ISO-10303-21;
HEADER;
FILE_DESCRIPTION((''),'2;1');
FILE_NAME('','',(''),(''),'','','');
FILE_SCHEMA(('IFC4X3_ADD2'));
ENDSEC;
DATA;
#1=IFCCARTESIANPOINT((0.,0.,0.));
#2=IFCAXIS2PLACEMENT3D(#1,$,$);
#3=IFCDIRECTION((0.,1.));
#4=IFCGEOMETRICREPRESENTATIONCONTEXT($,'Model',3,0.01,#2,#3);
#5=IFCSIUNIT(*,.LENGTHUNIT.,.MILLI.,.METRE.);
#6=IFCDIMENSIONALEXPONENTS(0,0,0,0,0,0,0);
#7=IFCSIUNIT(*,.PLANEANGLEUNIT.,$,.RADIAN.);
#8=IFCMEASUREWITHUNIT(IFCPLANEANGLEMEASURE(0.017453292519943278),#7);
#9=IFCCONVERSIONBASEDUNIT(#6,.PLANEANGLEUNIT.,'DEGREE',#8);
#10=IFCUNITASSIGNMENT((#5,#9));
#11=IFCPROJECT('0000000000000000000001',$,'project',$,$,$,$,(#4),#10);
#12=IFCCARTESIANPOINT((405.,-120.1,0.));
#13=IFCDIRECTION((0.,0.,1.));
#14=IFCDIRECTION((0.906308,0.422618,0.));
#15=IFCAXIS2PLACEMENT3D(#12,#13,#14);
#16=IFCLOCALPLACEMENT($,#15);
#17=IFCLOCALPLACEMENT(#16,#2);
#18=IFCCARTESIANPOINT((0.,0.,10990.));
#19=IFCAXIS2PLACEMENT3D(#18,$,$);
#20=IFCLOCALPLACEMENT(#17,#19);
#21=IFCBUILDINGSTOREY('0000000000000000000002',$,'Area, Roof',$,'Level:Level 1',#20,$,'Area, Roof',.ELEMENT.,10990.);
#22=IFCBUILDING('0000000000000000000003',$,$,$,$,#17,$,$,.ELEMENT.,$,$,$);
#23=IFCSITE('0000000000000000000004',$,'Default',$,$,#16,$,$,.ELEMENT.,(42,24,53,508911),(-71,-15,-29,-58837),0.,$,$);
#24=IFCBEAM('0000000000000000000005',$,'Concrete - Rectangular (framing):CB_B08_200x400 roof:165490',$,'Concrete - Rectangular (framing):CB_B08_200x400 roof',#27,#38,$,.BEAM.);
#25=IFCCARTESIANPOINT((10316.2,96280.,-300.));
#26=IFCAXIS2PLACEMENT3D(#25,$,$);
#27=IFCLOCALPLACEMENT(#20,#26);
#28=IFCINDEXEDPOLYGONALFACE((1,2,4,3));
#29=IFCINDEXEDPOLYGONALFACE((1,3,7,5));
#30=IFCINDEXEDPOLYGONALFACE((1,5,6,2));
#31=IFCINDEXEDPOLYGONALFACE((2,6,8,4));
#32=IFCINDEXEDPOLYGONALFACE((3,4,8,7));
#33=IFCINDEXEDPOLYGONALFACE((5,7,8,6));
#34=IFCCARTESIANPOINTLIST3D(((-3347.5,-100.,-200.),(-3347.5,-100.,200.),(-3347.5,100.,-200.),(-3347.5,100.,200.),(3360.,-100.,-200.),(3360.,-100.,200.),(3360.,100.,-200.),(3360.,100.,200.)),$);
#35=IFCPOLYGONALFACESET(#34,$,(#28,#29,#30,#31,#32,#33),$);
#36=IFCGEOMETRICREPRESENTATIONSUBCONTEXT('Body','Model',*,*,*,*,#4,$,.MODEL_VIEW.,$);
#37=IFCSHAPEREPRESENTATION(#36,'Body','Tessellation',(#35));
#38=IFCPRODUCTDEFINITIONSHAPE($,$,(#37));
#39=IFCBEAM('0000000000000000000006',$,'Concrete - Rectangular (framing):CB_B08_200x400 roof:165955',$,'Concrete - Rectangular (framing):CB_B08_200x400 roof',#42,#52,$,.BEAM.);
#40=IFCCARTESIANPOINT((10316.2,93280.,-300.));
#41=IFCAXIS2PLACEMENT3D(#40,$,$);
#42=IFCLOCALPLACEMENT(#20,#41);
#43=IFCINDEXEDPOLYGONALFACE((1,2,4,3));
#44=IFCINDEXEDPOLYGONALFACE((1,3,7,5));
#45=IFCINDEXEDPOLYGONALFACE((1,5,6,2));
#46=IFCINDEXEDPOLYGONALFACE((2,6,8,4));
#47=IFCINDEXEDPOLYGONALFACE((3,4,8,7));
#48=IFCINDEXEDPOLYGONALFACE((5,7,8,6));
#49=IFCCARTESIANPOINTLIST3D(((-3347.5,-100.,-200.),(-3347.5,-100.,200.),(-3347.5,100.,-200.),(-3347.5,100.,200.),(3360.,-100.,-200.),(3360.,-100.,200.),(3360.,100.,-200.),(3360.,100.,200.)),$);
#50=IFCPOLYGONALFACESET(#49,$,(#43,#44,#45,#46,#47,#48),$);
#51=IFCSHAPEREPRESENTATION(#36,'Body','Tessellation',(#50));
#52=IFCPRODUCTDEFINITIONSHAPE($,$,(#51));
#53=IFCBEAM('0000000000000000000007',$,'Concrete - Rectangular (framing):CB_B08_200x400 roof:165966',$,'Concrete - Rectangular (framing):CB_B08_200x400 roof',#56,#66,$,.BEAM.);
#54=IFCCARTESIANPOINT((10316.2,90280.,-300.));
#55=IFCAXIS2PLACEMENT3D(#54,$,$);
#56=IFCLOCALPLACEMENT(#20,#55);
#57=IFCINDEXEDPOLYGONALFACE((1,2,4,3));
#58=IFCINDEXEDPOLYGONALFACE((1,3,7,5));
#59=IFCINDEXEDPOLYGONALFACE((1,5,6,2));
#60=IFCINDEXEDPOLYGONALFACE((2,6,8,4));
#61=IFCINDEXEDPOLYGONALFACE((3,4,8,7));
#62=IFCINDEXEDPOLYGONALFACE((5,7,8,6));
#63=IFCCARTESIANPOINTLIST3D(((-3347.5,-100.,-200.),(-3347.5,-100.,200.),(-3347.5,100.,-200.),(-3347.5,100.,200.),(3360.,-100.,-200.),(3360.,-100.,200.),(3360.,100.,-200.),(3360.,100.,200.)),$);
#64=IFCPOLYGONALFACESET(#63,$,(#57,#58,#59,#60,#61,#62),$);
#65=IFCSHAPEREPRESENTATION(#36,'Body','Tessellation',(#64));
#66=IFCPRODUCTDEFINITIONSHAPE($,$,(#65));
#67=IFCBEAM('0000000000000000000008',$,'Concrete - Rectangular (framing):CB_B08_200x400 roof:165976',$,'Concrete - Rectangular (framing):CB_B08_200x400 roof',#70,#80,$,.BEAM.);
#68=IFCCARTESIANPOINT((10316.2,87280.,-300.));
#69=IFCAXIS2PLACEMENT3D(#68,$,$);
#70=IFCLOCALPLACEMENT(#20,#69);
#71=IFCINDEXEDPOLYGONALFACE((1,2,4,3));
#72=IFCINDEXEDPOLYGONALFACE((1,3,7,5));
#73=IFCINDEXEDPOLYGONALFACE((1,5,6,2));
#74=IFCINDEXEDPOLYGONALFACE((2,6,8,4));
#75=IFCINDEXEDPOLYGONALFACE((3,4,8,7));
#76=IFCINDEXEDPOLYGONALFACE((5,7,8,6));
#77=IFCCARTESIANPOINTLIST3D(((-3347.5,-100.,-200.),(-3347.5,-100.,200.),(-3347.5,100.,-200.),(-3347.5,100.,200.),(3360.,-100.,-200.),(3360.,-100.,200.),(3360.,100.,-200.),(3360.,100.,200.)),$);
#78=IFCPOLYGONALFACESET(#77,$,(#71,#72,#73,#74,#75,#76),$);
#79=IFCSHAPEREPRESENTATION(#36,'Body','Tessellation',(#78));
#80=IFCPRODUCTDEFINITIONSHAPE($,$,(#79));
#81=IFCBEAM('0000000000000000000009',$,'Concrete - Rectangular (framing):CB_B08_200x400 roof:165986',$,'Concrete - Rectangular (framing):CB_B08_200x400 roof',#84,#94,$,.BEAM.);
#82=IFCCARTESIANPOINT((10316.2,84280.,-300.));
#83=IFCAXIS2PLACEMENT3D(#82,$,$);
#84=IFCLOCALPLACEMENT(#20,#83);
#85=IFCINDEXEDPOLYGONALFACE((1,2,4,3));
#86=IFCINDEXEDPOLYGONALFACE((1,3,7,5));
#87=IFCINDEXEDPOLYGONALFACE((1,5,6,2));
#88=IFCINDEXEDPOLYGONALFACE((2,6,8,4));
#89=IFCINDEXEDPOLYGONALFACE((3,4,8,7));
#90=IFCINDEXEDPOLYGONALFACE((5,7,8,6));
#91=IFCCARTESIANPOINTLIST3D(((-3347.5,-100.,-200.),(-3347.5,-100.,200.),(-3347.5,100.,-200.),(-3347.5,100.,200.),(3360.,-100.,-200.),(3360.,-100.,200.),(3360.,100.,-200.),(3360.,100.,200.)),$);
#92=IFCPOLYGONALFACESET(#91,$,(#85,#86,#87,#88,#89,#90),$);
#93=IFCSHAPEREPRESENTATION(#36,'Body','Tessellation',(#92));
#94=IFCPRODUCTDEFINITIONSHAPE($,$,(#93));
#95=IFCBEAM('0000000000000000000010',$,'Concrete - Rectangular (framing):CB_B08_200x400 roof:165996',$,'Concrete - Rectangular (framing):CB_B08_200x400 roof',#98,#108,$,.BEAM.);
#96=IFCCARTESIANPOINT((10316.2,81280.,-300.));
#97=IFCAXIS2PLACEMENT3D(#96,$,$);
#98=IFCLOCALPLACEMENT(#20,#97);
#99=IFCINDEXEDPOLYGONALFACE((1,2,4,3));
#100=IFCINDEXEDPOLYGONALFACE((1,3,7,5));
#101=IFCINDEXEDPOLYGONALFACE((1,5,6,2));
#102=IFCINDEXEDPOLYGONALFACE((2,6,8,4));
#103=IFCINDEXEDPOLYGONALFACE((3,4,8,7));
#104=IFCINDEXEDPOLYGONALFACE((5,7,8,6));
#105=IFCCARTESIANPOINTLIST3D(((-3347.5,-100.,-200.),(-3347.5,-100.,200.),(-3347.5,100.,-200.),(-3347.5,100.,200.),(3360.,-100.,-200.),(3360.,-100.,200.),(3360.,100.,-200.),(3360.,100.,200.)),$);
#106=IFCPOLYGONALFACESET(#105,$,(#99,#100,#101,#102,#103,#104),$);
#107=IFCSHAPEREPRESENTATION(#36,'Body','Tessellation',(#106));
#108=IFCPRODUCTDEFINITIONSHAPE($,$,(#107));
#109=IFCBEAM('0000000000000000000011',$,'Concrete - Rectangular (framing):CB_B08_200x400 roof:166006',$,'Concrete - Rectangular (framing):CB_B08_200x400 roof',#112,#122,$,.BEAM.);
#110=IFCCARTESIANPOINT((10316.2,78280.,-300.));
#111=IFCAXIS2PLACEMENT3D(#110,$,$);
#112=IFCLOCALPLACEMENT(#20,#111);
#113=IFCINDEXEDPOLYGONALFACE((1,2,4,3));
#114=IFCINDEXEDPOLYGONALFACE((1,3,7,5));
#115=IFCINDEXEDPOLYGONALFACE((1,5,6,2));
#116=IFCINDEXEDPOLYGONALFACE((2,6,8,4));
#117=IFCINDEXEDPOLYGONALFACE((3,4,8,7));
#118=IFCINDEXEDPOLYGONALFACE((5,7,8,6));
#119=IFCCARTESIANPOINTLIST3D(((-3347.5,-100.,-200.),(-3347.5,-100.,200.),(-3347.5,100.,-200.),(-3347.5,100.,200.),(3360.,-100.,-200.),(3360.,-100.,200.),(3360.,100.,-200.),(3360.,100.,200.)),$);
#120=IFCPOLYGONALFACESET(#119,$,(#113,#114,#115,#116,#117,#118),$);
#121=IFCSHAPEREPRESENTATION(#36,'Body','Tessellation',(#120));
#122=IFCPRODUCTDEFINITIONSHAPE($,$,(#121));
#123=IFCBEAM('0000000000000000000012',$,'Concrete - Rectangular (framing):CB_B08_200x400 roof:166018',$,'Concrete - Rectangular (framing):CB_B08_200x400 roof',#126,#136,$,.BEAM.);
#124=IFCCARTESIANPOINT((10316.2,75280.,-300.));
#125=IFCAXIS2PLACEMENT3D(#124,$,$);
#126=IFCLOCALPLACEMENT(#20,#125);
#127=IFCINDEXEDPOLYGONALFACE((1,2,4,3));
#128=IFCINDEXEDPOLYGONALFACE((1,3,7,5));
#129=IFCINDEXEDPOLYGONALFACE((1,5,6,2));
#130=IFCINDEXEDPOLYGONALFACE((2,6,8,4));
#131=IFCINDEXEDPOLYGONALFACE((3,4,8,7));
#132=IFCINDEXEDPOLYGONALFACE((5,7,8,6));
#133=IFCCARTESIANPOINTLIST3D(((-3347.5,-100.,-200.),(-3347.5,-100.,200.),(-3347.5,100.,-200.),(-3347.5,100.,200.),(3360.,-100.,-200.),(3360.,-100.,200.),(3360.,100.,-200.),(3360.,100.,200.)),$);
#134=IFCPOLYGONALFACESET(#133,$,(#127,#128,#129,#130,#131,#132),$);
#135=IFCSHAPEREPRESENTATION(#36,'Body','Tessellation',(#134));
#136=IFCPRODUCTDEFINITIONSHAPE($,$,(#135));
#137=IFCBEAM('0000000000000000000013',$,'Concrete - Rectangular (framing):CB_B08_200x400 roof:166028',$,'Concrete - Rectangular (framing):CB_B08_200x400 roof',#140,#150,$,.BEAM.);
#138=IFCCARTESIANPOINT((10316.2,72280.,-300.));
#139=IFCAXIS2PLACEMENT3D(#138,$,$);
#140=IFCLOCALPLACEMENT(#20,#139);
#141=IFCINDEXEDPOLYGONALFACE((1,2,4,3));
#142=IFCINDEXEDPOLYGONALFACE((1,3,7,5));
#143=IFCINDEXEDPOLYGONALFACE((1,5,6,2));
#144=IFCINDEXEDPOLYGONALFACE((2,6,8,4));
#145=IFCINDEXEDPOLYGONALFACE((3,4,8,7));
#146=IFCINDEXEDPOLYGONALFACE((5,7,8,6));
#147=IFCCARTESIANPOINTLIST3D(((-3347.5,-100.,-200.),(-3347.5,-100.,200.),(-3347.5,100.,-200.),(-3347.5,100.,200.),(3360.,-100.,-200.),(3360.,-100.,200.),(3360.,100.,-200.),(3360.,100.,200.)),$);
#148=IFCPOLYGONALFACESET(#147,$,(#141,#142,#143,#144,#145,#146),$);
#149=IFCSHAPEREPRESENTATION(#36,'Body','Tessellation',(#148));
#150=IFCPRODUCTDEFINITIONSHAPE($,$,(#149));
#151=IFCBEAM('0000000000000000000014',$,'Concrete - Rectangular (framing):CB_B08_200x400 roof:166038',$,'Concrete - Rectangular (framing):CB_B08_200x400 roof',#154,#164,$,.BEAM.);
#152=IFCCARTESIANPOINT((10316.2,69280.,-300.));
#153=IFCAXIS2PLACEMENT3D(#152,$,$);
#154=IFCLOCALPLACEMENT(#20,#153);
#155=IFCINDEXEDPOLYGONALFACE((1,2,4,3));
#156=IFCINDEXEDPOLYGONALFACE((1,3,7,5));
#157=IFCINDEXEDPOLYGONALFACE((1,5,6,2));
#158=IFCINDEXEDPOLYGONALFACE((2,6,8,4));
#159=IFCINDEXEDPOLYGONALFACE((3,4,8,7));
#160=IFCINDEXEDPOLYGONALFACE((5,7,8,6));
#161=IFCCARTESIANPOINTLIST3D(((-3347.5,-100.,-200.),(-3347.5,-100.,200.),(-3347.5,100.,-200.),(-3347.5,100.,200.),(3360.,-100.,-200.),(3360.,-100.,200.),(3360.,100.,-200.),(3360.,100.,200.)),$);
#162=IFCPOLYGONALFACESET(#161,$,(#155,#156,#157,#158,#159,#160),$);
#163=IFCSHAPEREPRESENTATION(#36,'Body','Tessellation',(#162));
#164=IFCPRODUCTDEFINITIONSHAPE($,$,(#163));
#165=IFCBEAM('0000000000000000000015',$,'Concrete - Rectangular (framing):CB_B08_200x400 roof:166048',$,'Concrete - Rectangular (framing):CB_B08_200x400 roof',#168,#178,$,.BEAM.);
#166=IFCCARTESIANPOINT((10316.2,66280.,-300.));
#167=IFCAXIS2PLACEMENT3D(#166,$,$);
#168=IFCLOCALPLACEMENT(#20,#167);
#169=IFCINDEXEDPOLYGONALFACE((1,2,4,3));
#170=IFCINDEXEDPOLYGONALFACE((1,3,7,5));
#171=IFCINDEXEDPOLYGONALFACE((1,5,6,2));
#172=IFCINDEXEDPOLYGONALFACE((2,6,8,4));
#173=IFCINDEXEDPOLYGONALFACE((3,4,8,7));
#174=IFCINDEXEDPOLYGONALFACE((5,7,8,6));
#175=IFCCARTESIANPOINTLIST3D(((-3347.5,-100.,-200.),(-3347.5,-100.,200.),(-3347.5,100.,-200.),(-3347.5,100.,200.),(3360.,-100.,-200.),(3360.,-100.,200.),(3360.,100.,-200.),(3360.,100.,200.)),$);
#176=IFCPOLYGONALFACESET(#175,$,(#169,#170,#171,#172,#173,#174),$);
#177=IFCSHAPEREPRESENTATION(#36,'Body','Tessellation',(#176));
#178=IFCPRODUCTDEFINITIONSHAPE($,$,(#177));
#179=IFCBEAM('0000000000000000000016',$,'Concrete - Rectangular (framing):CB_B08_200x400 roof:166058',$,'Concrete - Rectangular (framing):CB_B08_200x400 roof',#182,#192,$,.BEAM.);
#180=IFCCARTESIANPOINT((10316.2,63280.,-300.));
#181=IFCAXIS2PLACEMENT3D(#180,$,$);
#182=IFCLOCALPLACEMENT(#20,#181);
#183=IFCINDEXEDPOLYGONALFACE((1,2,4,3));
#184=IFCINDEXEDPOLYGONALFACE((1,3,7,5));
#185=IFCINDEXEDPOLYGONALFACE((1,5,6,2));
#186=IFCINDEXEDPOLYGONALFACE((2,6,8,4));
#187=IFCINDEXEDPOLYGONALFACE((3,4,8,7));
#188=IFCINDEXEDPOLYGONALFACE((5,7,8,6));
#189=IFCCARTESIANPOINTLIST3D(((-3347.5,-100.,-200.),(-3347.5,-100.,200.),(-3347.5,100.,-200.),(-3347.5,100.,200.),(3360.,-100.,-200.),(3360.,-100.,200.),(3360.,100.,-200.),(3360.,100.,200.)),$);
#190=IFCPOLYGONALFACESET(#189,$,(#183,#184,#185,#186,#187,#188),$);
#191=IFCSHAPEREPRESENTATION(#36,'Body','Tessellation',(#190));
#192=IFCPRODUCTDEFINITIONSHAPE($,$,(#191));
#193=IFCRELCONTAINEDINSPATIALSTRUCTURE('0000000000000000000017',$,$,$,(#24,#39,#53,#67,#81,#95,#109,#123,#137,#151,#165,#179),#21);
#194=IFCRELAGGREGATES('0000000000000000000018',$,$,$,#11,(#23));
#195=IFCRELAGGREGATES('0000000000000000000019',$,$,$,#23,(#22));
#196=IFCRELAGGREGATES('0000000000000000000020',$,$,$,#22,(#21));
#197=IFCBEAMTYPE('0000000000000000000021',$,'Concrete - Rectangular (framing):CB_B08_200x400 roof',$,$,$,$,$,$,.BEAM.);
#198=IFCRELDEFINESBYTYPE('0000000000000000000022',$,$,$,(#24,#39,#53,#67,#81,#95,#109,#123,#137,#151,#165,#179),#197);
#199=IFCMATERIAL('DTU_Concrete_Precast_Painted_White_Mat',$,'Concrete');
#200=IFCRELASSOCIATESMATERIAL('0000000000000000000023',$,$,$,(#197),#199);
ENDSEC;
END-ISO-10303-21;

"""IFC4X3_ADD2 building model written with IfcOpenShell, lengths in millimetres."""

from ifc_helpers import new_model, entity, si_unit, converted_unit, direction, frame, origin, origin_2d_with_axis, place, context, subcontext, project, spatial, rectangle, extrude, source, transform, mapped, material, material_profile, profile_set, type_object, type_shapes, element, save


model = new_model("IFC4X3_ADD2")

# Units and contexts
model_context = context("Model", 3, precision=0.01, world=origin(), true_north=direction((0.0, 1.0)))
body_context = subcontext(model_context, "Body", "Model", "MODEL_VIEW")
ifc_project = project(units=[si_unit("LENGTHUNIT", "METRE", prefix="MILLI"), converted_unit("PLANEANGLEUNIT", "DEGREE", entity("IfcPlaneAngleMeasure", 0.017453292519943278), si_unit("PLANEANGLEUNIT", "RADIAN"), dimensions=[0, 0, 0, 0, 0, 0, 0])], contexts=[model_context])

# Site, building, storey
site_placement = place(None, frame((405.0, -120.1, 0.0), z_axis=(0.0, 0.0, 1.0), x_axis=(0.906308, 0.422618, 0.0)))
site = spatial("IfcSite", under=ifc_project, at=site_placement, Name="Default", CompositionType="ELEMENT", RefLatitude=(42, 24, 53, 508911), RefLongitude=(-71, -15, -29, -58837), RefElevation=0.0)
building_placement = place(site_placement, origin())
building = spatial("IfcBuilding", under=site, at=building_placement, CompositionType="ELEMENT")
storey_placement = place(building_placement, frame((0.0, 0.0, 10990.0)))
storey = spatial("IfcBuildingStorey", under=building, at=storey_placement, Name="Area, Roof", ObjectType="Level:Level 1", LongName="Area, Roof", CompositionType="ELEMENT", Elevation=10990.0)

# Beams
ifc_material = material(Name="DTU_Concrete_Precast_Painted_White_Mat", Category="Concrete")
ifc_material_profile = material_profile(ifc_material, rectangle(XDim=7137.5, YDim=200.0, at=origin_2d_with_axis()), Name="CB_B08_200x400 roof")
ifc_profile_set = profile_set([ifc_material_profile], Name="CB_B08_200x400 roof")
beam_type_1 = type_object("IfcBeamType", Name="Concrete - Rectangular (framing):CB_B08_200x400 roof", PredefinedType="BEAM", material=ifc_profile_set)
shared_shape_1 = source(origin(), body_context, "Body", "SweptSolid", [
    extrude(rectangle(XDim=6707.5, YDim=200.0, at=origin_2d_with_axis()), frame((6.3, 0.0, -200.0), z_axis=(0.0, 0.0, 1.0), x_axis=(-1.0, 0.0, 0.0)), (0.0, 0.0, 1.0), 400.0),
])
type_shapes(beam_type_1, [shared_shape_1])
for number, where, name in (
    (1, (10316.2, 96280.0, -300.0), "Concrete - Rectangular (framing):CB_B08_200x400 roof:165490"),
    (2, (10316.2, 93280.0, -300.0), "Concrete - Rectangular (framing):CB_B08_200x400 roof:165955"),
    (3, (10316.2, 90280.0, -300.0), "Concrete - Rectangular (framing):CB_B08_200x400 roof:165966"),
    (4, (10316.2, 87280.0, -300.0), "Concrete - Rectangular (framing):CB_B08_200x400 roof:165976"),
    (5, (10316.2, 84280.0, -300.0), "Concrete - Rectangular (framing):CB_B08_200x400 roof:165986"),
    (6, (10316.2, 81280.0, -300.0), "Concrete - Rectangular (framing):CB_B08_200x400 roof:165996"),
    (7, (10316.2, 78280.0, -300.0), "Concrete - Rectangular (framing):CB_B08_200x400 roof:166006"),
    (8, (10316.2, 75280.0, -300.0), "Concrete - Rectangular (framing):CB_B08_200x400 roof:166018"),
    (9, (10316.2, 72280.0, -300.0), "Concrete - Rectangular (framing):CB_B08_200x400 roof:166028"),
    (10, (10316.2, 69280.0, -300.0), "Concrete - Rectangular (framing):CB_B08_200x400 roof:166038"),
    (11, (10316.2, 66280.0, -300.0), "Concrete - Rectangular (framing):CB_B08_200x400 roof:166048"),
    (12, (10316.2, 63280.0, -300.0), "Concrete - Rectangular (framing):CB_B08_200x400 roof:166058"),
):
    element("IfcBeam", number, at=place(storey_placement, frame(where)), inside=storey, type_object=beam_type_1, Name=name, ObjectType="Concrete - Rectangular (framing):CB_B08_200x400 roof", PredefinedType="BEAM", context=body_context, shape_type="MappedRepresentation", body=[
        mapped(shared_shape_1, transform((0.0, 0.0, 0.0), scale=1.0)),
    ])

save(model, "model.ifc")
